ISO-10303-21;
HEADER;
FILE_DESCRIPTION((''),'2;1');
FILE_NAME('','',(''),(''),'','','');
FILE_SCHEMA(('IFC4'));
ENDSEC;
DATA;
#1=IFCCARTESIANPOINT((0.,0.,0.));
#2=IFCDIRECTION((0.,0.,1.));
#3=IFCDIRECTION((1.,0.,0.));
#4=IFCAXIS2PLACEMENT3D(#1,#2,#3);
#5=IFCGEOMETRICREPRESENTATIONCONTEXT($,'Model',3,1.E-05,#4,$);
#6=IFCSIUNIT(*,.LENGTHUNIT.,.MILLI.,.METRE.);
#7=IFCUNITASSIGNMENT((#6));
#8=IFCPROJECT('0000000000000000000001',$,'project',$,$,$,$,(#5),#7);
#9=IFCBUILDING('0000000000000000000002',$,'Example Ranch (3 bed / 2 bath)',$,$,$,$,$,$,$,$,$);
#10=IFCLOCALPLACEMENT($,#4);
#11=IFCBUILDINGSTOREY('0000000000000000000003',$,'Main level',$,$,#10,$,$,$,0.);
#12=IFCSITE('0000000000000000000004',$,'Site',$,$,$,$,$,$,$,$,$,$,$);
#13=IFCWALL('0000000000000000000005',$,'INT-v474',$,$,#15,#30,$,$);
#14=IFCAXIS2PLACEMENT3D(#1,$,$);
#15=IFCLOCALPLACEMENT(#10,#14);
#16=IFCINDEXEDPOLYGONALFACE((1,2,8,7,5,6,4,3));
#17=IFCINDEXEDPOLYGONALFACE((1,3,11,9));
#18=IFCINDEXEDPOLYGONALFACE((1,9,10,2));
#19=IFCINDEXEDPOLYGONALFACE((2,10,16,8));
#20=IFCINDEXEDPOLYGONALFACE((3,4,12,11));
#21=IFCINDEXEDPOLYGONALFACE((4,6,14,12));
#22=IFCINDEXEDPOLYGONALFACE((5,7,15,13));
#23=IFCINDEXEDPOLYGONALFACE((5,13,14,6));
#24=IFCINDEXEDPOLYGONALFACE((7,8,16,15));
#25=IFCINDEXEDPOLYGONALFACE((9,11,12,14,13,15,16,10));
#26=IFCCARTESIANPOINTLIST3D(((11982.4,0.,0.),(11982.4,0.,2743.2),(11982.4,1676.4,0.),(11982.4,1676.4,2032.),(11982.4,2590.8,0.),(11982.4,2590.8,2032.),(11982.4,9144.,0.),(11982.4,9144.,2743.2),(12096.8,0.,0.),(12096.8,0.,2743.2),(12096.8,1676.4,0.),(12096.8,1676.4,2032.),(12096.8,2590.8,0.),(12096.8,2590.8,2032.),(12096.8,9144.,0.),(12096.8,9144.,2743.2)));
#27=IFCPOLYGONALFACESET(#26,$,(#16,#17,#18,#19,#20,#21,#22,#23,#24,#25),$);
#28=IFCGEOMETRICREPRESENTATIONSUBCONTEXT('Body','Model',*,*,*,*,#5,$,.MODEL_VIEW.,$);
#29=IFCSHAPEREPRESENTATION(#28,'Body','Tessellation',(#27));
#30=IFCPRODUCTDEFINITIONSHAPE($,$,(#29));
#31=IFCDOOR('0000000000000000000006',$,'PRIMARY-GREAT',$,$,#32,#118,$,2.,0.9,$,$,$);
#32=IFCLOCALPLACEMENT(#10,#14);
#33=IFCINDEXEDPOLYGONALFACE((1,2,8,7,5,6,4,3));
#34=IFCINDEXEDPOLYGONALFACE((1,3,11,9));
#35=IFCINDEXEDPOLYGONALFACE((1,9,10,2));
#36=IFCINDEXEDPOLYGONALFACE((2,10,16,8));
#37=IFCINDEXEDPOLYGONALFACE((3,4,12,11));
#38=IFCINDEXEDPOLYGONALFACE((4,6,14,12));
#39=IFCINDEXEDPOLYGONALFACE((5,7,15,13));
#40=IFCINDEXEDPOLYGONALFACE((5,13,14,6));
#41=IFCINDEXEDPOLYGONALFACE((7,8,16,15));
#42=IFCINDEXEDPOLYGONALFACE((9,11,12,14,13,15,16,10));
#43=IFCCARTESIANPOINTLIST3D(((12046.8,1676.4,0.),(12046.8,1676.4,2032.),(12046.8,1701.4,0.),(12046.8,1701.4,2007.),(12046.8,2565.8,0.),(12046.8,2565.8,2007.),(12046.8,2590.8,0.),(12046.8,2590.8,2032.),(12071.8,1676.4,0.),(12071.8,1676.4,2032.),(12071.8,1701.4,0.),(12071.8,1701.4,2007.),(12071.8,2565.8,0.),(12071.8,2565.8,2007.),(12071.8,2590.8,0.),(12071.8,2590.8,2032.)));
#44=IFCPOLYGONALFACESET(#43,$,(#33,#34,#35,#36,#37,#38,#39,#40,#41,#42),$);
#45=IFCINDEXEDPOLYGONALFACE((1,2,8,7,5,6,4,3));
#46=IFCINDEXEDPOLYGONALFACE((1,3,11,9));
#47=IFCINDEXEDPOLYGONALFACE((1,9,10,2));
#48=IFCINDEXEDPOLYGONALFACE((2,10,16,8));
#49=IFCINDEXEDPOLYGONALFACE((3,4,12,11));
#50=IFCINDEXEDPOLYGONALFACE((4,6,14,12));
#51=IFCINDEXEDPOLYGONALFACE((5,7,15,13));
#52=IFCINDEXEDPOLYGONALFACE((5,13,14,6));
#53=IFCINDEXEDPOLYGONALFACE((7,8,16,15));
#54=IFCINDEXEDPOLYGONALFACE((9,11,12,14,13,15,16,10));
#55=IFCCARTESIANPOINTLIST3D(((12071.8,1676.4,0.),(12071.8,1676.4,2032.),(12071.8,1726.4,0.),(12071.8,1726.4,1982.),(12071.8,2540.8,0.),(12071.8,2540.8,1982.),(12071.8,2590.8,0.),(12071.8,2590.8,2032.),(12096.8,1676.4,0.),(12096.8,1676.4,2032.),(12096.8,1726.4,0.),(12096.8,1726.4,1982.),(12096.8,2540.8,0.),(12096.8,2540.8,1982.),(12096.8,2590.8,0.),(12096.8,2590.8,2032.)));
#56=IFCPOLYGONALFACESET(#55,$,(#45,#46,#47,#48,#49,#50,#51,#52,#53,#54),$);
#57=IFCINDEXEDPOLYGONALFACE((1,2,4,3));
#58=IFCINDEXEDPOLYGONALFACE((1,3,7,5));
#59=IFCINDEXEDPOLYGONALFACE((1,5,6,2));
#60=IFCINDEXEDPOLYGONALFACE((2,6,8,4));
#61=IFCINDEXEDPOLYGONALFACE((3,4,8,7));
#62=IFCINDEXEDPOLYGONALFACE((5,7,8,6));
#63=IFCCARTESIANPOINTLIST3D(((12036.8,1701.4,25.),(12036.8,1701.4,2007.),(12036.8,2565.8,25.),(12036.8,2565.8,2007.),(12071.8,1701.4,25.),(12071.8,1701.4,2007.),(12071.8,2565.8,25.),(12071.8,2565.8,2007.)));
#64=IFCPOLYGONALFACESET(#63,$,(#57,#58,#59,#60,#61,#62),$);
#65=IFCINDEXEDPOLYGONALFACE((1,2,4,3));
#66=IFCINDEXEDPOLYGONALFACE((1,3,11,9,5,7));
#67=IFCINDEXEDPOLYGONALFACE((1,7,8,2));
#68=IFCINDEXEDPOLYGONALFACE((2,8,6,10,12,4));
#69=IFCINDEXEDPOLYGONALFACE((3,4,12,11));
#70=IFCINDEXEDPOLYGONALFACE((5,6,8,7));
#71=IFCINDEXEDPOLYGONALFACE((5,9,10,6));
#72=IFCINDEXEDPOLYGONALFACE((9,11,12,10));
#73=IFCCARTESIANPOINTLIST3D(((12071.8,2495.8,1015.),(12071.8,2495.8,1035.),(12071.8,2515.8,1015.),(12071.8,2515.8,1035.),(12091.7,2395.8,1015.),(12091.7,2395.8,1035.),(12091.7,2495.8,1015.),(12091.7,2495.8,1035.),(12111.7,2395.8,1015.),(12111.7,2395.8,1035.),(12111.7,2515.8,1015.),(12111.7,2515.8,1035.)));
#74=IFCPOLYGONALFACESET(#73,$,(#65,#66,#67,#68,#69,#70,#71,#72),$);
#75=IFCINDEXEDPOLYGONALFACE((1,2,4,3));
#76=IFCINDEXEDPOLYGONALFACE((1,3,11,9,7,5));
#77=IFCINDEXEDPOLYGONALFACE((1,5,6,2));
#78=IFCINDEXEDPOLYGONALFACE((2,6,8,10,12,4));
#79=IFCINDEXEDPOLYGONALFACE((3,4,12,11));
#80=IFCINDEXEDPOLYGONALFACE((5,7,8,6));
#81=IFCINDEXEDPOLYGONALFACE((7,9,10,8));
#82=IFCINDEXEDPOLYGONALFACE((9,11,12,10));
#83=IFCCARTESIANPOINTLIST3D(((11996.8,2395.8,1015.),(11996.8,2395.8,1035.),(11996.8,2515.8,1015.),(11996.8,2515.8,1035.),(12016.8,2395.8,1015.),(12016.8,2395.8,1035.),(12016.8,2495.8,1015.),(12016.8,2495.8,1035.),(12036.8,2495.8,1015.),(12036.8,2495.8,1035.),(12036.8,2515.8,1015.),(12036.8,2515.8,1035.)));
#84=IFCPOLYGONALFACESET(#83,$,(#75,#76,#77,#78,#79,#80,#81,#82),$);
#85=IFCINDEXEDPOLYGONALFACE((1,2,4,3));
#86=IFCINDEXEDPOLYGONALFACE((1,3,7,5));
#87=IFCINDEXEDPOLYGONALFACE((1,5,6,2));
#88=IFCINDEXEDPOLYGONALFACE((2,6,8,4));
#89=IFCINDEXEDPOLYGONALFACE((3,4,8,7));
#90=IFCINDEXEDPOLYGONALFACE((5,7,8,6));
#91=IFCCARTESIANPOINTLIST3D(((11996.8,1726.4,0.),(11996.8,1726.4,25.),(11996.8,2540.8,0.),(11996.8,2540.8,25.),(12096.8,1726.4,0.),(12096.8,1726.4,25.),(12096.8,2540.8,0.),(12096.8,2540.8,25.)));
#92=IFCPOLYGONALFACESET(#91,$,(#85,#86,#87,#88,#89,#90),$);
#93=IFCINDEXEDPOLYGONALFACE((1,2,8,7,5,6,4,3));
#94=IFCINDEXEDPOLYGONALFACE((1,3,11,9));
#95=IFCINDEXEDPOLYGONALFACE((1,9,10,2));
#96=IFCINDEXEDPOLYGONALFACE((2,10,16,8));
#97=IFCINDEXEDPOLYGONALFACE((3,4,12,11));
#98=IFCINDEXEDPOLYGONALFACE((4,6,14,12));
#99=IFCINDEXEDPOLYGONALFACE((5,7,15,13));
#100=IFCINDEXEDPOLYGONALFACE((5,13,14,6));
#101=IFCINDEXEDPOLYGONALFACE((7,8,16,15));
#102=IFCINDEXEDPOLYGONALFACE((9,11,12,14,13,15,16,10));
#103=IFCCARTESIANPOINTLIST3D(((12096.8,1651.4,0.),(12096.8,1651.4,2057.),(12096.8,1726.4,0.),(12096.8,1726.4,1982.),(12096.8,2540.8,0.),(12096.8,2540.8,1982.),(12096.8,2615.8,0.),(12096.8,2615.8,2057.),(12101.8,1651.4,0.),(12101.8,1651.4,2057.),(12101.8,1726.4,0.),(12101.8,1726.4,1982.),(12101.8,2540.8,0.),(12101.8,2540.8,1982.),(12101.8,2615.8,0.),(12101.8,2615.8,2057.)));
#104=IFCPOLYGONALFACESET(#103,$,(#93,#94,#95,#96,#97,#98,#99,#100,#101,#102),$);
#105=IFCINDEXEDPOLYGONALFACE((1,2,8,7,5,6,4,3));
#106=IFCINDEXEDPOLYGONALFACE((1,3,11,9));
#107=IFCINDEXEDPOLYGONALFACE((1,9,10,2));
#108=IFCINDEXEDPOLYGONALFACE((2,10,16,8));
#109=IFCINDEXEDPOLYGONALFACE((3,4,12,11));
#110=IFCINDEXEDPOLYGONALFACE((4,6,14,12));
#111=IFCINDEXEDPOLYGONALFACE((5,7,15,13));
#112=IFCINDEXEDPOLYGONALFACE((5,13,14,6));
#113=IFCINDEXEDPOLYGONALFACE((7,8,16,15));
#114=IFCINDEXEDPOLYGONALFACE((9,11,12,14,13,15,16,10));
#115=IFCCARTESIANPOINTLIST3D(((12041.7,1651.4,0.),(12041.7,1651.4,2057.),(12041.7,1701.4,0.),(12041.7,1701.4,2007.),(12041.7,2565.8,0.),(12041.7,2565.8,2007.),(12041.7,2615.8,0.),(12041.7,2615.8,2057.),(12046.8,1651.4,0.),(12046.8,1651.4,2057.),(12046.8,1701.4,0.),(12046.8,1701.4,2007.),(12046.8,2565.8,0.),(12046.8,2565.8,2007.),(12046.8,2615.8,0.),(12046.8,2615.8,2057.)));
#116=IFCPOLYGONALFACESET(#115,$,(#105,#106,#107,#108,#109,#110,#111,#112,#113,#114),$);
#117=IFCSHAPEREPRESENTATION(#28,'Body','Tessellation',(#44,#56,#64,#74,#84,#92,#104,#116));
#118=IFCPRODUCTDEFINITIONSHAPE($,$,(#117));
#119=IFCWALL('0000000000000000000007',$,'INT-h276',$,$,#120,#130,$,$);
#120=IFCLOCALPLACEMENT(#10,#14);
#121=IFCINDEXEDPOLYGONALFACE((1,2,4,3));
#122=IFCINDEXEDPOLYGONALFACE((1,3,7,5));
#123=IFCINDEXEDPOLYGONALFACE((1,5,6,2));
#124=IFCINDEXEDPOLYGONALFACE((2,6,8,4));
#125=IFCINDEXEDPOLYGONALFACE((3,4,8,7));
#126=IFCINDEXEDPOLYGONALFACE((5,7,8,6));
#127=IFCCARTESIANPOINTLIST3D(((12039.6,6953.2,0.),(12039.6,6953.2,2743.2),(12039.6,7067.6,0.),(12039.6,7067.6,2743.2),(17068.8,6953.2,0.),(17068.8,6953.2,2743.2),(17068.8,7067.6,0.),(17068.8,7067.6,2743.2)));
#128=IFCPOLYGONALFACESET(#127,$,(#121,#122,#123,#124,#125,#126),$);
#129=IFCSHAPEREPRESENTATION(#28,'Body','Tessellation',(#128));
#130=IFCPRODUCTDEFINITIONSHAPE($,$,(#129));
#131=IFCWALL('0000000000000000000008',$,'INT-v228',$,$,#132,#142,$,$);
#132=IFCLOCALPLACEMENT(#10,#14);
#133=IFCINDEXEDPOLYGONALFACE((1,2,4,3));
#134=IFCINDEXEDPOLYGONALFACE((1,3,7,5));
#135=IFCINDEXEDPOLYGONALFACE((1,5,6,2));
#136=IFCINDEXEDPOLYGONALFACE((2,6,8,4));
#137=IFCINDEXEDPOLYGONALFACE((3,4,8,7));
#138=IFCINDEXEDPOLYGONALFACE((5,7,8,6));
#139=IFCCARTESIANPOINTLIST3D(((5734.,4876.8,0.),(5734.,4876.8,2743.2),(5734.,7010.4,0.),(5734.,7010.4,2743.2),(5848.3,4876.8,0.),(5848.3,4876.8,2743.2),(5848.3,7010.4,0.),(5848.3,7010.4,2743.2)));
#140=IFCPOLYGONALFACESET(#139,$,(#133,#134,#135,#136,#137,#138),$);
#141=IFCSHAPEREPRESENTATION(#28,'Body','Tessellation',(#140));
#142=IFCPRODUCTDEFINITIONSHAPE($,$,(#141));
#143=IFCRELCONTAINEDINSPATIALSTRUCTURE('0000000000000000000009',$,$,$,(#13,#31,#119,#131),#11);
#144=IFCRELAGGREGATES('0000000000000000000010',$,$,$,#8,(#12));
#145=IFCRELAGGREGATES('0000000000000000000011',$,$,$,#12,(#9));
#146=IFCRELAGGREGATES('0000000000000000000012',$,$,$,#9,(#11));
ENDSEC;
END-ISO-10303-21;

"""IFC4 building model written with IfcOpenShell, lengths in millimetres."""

from ifc_helpers import new_model, si_unit, frame, origin_with_axes, place, context, subcontext, project, spatial, line, indexed_curve, outline, extrude, element, fill, save


model = new_model("IFC4")

# Units and contexts
model_context = context("Model", 3, precision=1e-05, world=origin_with_axes())
body_context = subcontext(model_context, "Body", "Model", "MODEL_VIEW")
ifc_project = project(units=[si_unit("LENGTHUNIT", "METRE", prefix="MILLI")], contexts=[model_context])

# Site, building, storey
site = spatial("IfcSite", under=ifc_project, Name="Site")
building = spatial("IfcBuilding", under=site, Name="Example Ranch (3 bed / 2 bath)")
storey_placement = place(None, origin_with_axes())
storey = spatial("IfcBuildingStorey", under=building, at=storey_placement, Name="Main level", Elevation=0.0)

# Wall, opening, door
wall_1_placement = place(storey_placement, frame((12096.8, 0.0, 0.0), z_axis=(0.0, 0.0, 1.0), x_axis=(0.0, 1.0, 0.0)))
wall_1 = element("IfcWall", 1, at=wall_1_placement, inside=storey, Name="INT-v474", context=body_context, shape_type="SweptSolid", body=[
    extrude(outline(indexed_curve([(0.0, 0.0), (0.0, 114.3), (9144.0, 114.3), (9144.0, 0.0), (0.0, 0.0)], self_intersect=False)), origin_with_axes(), (0.0, 0.0, 1.0), 2743.2),
])
opening_1_placement = place(wall_1_placement, frame((1676.4, 0.0, 0.0), z_axis=(0.0, 0.0, 1.0), x_axis=(1.0, 0.0, 0.0)))
opening_1 = element("IfcOpeningElement", 2, at=opening_1_placement, cuts=wall_1, context=body_context, shape_type="SweptSolid", body=[
    extrude(outline(indexed_curve([(0.0, 0.0), (0.0, 114.3), (914.4, 114.3), (914.4, 0.0), (0.0, 0.0)], self_intersect=False)), origin_with_axes(), (0.0, 0.0, 1.0), 2032.0),
])
door_1_placement = place(storey_placement, frame((12096.8, 1676.4, 0.0), z_axis=(0.0, 0.0, 1.0), x_axis=(0.0, 1.0, 0.0)))
door_1 = element("IfcDoor", 3, at=door_1_placement, inside=storey, Name="PRIMARY-GREAT", OverallHeight=2.0, OverallWidth=0.9, context=body_context, shape_type="SweptSolid", body=[
    extrude(outline(indexed_curve([(0.0, 0.0), (0.0, 2032.0), (914.4, 2032.0), (914.4, 0.0), (889.4, 0.0), (889.4, 2007.0), (25.0, 2007.0), (25.0, 0.0)], segments=[line(1, 2, 3, 4, 5, 6, 7, 8, 1)])), frame((0.0, 25.0, 0.0), z_axis=(0.0, -1.0, 0.0), x_axis=(1.0, 0.0, 0.0)), (0.0, 0.0, -1.0), 25.0),
    extrude(outline(indexed_curve([(0.0, 0.0), (0.0, 2032.0), (914.4, 2032.0), (914.4, 0.0), (864.4, 0.0), (864.4, 1982.0), (50.0, 1982.0), (50.0, 0.0)], segments=[line(1, 2, 3, 4, 5, 6, 7, 8, 1)])), frame((0.0, 0.0, 0.0), z_axis=(0.0, -1.0, 0.0), x_axis=(1.0, 0.0, 0.0)), (0.0, 0.0, -1.0), 25.0),
    extrude(outline(indexed_curve([(0.0, 0.0), (864.4, 0.0), (864.4, 35.0), (0.0, 35.0)], segments=[line(1, 2, 3, 4, 1)])), frame((25.0, 25.0, 25.0), z_axis=(0.0, 0.0, 1.0), x_axis=(1.0, 0.0, 0.0)), (0.0, 0.0, 1.0), 1982.0),
    extrude(outline(indexed_curve([(0.0, 0.0), (0.0, -40.0), (-120.0, -40.0), (-120.0, -20.0), (-20.0, -20.0), (-20.0, 0.0)], segments=[line(1, 2, 3, 4, 5, 6, 1)])), frame((839.4, 25.0, 1015.0), z_axis=(0.0, 0.0, 1.0), x_axis=(1.0, 0.0, 0.0)), (0.0, 0.0, 1.0), 20.0),
    extrude(outline(indexed_curve([(0.0, 0.0), (0.0, 40.0), (-120.0, 40.0), (-120.0, 20.0), (-20.0, 20.0), (-20.0, 0.0)], segments=[line(1, 2, 3, 4, 5, 6, 1)])), frame((839.4, 60.0, 1015.0), z_axis=(0.0, 0.0, 1.0), x_axis=(1.0, 0.0, 0.0)), (0.0, 0.0, 1.0), 20.0),
    extrude(outline(indexed_curve([(0.0, 0.0), (814.4, 0.0), (814.4, 100.0), (0.0, 100.0)], segments=[line(1, 2, 3, 4, 1)])), frame((50.0, 0.0, 0.0), z_axis=(0.0, 0.0, 1.0), x_axis=(1.0, 0.0, 0.0)), (0.0, 0.0, 1.0), 25.0),
    extrude(outline(indexed_curve([(0.0, 0.0), (0.0, 2057.0), (964.4, 2057.0), (964.4, 0.0), (889.4, 0.0), (889.4, 1982.0), (75.0, 1982.0), (75.0, 0.0)], segments=[line(1, 2, 3, 4, 5, 6, 7, 8, 1)])), frame((-25.0, -5.0, 0.0), z_axis=(0.0, -1.0, 0.0), x_axis=(1.0, 0.0, 0.0)), (0.0, 0.0, -1.0), 5.0),
    extrude(outline(indexed_curve([(0.0, 0.0), (0.0, 2057.0), (964.4, 2057.0), (964.4, 0.0), (914.4, 0.0), (914.4, 2007.0), (50.0, 2007.0), (50.0, 0.0)], segments=[line(1, 2, 3, 4, 5, 6, 7, 8, 1)])), frame((-25.0, 50.0, 0.0), z_axis=(0.0, -1.0, 0.0), x_axis=(1.0, 0.0, 0.0)), (0.0, 0.0, -1.0), 5.0),
])
fill(opening_1, door_1)

# Walls
wall_2_placement = place(storey_placement, frame((12039.6, 6953.2, 0.0), z_axis=(0.0, 0.0, 1.0), x_axis=(1.0, 0.0, 0.0)))
element("IfcWall", 4, at=wall_2_placement, inside=storey, Name="INT-h276", context=body_context, shape_type="SweptSolid", body=[
    extrude(outline(indexed_curve([(0.0, 0.0), (0.0, 114.3), (5029.2, 114.3), (5029.2, 0.0), (0.0, 0.0)], self_intersect=False)), origin_with_axes(), (0.0, 0.0, 1.0), 2743.2),
])
wall_3_placement = place(storey_placement, frame((5848.3, 4876.8, 0.0), z_axis=(0.0, 0.0, 1.0), x_axis=(0.0, 1.0, 0.0)))
element("IfcWall", 5, at=wall_3_placement, inside=storey, Name="INT-v228", context=body_context, shape_type="SweptSolid", body=[
    extrude(outline(indexed_curve([(0.0, 0.0), (0.0, 114.3), (2133.6, 114.3), (2133.6, 0.0), (0.0, 0.0)], self_intersect=False)), origin_with_axes(), (0.0, 0.0, 1.0), 2743.2),
])

save(model, "model.ifc")
